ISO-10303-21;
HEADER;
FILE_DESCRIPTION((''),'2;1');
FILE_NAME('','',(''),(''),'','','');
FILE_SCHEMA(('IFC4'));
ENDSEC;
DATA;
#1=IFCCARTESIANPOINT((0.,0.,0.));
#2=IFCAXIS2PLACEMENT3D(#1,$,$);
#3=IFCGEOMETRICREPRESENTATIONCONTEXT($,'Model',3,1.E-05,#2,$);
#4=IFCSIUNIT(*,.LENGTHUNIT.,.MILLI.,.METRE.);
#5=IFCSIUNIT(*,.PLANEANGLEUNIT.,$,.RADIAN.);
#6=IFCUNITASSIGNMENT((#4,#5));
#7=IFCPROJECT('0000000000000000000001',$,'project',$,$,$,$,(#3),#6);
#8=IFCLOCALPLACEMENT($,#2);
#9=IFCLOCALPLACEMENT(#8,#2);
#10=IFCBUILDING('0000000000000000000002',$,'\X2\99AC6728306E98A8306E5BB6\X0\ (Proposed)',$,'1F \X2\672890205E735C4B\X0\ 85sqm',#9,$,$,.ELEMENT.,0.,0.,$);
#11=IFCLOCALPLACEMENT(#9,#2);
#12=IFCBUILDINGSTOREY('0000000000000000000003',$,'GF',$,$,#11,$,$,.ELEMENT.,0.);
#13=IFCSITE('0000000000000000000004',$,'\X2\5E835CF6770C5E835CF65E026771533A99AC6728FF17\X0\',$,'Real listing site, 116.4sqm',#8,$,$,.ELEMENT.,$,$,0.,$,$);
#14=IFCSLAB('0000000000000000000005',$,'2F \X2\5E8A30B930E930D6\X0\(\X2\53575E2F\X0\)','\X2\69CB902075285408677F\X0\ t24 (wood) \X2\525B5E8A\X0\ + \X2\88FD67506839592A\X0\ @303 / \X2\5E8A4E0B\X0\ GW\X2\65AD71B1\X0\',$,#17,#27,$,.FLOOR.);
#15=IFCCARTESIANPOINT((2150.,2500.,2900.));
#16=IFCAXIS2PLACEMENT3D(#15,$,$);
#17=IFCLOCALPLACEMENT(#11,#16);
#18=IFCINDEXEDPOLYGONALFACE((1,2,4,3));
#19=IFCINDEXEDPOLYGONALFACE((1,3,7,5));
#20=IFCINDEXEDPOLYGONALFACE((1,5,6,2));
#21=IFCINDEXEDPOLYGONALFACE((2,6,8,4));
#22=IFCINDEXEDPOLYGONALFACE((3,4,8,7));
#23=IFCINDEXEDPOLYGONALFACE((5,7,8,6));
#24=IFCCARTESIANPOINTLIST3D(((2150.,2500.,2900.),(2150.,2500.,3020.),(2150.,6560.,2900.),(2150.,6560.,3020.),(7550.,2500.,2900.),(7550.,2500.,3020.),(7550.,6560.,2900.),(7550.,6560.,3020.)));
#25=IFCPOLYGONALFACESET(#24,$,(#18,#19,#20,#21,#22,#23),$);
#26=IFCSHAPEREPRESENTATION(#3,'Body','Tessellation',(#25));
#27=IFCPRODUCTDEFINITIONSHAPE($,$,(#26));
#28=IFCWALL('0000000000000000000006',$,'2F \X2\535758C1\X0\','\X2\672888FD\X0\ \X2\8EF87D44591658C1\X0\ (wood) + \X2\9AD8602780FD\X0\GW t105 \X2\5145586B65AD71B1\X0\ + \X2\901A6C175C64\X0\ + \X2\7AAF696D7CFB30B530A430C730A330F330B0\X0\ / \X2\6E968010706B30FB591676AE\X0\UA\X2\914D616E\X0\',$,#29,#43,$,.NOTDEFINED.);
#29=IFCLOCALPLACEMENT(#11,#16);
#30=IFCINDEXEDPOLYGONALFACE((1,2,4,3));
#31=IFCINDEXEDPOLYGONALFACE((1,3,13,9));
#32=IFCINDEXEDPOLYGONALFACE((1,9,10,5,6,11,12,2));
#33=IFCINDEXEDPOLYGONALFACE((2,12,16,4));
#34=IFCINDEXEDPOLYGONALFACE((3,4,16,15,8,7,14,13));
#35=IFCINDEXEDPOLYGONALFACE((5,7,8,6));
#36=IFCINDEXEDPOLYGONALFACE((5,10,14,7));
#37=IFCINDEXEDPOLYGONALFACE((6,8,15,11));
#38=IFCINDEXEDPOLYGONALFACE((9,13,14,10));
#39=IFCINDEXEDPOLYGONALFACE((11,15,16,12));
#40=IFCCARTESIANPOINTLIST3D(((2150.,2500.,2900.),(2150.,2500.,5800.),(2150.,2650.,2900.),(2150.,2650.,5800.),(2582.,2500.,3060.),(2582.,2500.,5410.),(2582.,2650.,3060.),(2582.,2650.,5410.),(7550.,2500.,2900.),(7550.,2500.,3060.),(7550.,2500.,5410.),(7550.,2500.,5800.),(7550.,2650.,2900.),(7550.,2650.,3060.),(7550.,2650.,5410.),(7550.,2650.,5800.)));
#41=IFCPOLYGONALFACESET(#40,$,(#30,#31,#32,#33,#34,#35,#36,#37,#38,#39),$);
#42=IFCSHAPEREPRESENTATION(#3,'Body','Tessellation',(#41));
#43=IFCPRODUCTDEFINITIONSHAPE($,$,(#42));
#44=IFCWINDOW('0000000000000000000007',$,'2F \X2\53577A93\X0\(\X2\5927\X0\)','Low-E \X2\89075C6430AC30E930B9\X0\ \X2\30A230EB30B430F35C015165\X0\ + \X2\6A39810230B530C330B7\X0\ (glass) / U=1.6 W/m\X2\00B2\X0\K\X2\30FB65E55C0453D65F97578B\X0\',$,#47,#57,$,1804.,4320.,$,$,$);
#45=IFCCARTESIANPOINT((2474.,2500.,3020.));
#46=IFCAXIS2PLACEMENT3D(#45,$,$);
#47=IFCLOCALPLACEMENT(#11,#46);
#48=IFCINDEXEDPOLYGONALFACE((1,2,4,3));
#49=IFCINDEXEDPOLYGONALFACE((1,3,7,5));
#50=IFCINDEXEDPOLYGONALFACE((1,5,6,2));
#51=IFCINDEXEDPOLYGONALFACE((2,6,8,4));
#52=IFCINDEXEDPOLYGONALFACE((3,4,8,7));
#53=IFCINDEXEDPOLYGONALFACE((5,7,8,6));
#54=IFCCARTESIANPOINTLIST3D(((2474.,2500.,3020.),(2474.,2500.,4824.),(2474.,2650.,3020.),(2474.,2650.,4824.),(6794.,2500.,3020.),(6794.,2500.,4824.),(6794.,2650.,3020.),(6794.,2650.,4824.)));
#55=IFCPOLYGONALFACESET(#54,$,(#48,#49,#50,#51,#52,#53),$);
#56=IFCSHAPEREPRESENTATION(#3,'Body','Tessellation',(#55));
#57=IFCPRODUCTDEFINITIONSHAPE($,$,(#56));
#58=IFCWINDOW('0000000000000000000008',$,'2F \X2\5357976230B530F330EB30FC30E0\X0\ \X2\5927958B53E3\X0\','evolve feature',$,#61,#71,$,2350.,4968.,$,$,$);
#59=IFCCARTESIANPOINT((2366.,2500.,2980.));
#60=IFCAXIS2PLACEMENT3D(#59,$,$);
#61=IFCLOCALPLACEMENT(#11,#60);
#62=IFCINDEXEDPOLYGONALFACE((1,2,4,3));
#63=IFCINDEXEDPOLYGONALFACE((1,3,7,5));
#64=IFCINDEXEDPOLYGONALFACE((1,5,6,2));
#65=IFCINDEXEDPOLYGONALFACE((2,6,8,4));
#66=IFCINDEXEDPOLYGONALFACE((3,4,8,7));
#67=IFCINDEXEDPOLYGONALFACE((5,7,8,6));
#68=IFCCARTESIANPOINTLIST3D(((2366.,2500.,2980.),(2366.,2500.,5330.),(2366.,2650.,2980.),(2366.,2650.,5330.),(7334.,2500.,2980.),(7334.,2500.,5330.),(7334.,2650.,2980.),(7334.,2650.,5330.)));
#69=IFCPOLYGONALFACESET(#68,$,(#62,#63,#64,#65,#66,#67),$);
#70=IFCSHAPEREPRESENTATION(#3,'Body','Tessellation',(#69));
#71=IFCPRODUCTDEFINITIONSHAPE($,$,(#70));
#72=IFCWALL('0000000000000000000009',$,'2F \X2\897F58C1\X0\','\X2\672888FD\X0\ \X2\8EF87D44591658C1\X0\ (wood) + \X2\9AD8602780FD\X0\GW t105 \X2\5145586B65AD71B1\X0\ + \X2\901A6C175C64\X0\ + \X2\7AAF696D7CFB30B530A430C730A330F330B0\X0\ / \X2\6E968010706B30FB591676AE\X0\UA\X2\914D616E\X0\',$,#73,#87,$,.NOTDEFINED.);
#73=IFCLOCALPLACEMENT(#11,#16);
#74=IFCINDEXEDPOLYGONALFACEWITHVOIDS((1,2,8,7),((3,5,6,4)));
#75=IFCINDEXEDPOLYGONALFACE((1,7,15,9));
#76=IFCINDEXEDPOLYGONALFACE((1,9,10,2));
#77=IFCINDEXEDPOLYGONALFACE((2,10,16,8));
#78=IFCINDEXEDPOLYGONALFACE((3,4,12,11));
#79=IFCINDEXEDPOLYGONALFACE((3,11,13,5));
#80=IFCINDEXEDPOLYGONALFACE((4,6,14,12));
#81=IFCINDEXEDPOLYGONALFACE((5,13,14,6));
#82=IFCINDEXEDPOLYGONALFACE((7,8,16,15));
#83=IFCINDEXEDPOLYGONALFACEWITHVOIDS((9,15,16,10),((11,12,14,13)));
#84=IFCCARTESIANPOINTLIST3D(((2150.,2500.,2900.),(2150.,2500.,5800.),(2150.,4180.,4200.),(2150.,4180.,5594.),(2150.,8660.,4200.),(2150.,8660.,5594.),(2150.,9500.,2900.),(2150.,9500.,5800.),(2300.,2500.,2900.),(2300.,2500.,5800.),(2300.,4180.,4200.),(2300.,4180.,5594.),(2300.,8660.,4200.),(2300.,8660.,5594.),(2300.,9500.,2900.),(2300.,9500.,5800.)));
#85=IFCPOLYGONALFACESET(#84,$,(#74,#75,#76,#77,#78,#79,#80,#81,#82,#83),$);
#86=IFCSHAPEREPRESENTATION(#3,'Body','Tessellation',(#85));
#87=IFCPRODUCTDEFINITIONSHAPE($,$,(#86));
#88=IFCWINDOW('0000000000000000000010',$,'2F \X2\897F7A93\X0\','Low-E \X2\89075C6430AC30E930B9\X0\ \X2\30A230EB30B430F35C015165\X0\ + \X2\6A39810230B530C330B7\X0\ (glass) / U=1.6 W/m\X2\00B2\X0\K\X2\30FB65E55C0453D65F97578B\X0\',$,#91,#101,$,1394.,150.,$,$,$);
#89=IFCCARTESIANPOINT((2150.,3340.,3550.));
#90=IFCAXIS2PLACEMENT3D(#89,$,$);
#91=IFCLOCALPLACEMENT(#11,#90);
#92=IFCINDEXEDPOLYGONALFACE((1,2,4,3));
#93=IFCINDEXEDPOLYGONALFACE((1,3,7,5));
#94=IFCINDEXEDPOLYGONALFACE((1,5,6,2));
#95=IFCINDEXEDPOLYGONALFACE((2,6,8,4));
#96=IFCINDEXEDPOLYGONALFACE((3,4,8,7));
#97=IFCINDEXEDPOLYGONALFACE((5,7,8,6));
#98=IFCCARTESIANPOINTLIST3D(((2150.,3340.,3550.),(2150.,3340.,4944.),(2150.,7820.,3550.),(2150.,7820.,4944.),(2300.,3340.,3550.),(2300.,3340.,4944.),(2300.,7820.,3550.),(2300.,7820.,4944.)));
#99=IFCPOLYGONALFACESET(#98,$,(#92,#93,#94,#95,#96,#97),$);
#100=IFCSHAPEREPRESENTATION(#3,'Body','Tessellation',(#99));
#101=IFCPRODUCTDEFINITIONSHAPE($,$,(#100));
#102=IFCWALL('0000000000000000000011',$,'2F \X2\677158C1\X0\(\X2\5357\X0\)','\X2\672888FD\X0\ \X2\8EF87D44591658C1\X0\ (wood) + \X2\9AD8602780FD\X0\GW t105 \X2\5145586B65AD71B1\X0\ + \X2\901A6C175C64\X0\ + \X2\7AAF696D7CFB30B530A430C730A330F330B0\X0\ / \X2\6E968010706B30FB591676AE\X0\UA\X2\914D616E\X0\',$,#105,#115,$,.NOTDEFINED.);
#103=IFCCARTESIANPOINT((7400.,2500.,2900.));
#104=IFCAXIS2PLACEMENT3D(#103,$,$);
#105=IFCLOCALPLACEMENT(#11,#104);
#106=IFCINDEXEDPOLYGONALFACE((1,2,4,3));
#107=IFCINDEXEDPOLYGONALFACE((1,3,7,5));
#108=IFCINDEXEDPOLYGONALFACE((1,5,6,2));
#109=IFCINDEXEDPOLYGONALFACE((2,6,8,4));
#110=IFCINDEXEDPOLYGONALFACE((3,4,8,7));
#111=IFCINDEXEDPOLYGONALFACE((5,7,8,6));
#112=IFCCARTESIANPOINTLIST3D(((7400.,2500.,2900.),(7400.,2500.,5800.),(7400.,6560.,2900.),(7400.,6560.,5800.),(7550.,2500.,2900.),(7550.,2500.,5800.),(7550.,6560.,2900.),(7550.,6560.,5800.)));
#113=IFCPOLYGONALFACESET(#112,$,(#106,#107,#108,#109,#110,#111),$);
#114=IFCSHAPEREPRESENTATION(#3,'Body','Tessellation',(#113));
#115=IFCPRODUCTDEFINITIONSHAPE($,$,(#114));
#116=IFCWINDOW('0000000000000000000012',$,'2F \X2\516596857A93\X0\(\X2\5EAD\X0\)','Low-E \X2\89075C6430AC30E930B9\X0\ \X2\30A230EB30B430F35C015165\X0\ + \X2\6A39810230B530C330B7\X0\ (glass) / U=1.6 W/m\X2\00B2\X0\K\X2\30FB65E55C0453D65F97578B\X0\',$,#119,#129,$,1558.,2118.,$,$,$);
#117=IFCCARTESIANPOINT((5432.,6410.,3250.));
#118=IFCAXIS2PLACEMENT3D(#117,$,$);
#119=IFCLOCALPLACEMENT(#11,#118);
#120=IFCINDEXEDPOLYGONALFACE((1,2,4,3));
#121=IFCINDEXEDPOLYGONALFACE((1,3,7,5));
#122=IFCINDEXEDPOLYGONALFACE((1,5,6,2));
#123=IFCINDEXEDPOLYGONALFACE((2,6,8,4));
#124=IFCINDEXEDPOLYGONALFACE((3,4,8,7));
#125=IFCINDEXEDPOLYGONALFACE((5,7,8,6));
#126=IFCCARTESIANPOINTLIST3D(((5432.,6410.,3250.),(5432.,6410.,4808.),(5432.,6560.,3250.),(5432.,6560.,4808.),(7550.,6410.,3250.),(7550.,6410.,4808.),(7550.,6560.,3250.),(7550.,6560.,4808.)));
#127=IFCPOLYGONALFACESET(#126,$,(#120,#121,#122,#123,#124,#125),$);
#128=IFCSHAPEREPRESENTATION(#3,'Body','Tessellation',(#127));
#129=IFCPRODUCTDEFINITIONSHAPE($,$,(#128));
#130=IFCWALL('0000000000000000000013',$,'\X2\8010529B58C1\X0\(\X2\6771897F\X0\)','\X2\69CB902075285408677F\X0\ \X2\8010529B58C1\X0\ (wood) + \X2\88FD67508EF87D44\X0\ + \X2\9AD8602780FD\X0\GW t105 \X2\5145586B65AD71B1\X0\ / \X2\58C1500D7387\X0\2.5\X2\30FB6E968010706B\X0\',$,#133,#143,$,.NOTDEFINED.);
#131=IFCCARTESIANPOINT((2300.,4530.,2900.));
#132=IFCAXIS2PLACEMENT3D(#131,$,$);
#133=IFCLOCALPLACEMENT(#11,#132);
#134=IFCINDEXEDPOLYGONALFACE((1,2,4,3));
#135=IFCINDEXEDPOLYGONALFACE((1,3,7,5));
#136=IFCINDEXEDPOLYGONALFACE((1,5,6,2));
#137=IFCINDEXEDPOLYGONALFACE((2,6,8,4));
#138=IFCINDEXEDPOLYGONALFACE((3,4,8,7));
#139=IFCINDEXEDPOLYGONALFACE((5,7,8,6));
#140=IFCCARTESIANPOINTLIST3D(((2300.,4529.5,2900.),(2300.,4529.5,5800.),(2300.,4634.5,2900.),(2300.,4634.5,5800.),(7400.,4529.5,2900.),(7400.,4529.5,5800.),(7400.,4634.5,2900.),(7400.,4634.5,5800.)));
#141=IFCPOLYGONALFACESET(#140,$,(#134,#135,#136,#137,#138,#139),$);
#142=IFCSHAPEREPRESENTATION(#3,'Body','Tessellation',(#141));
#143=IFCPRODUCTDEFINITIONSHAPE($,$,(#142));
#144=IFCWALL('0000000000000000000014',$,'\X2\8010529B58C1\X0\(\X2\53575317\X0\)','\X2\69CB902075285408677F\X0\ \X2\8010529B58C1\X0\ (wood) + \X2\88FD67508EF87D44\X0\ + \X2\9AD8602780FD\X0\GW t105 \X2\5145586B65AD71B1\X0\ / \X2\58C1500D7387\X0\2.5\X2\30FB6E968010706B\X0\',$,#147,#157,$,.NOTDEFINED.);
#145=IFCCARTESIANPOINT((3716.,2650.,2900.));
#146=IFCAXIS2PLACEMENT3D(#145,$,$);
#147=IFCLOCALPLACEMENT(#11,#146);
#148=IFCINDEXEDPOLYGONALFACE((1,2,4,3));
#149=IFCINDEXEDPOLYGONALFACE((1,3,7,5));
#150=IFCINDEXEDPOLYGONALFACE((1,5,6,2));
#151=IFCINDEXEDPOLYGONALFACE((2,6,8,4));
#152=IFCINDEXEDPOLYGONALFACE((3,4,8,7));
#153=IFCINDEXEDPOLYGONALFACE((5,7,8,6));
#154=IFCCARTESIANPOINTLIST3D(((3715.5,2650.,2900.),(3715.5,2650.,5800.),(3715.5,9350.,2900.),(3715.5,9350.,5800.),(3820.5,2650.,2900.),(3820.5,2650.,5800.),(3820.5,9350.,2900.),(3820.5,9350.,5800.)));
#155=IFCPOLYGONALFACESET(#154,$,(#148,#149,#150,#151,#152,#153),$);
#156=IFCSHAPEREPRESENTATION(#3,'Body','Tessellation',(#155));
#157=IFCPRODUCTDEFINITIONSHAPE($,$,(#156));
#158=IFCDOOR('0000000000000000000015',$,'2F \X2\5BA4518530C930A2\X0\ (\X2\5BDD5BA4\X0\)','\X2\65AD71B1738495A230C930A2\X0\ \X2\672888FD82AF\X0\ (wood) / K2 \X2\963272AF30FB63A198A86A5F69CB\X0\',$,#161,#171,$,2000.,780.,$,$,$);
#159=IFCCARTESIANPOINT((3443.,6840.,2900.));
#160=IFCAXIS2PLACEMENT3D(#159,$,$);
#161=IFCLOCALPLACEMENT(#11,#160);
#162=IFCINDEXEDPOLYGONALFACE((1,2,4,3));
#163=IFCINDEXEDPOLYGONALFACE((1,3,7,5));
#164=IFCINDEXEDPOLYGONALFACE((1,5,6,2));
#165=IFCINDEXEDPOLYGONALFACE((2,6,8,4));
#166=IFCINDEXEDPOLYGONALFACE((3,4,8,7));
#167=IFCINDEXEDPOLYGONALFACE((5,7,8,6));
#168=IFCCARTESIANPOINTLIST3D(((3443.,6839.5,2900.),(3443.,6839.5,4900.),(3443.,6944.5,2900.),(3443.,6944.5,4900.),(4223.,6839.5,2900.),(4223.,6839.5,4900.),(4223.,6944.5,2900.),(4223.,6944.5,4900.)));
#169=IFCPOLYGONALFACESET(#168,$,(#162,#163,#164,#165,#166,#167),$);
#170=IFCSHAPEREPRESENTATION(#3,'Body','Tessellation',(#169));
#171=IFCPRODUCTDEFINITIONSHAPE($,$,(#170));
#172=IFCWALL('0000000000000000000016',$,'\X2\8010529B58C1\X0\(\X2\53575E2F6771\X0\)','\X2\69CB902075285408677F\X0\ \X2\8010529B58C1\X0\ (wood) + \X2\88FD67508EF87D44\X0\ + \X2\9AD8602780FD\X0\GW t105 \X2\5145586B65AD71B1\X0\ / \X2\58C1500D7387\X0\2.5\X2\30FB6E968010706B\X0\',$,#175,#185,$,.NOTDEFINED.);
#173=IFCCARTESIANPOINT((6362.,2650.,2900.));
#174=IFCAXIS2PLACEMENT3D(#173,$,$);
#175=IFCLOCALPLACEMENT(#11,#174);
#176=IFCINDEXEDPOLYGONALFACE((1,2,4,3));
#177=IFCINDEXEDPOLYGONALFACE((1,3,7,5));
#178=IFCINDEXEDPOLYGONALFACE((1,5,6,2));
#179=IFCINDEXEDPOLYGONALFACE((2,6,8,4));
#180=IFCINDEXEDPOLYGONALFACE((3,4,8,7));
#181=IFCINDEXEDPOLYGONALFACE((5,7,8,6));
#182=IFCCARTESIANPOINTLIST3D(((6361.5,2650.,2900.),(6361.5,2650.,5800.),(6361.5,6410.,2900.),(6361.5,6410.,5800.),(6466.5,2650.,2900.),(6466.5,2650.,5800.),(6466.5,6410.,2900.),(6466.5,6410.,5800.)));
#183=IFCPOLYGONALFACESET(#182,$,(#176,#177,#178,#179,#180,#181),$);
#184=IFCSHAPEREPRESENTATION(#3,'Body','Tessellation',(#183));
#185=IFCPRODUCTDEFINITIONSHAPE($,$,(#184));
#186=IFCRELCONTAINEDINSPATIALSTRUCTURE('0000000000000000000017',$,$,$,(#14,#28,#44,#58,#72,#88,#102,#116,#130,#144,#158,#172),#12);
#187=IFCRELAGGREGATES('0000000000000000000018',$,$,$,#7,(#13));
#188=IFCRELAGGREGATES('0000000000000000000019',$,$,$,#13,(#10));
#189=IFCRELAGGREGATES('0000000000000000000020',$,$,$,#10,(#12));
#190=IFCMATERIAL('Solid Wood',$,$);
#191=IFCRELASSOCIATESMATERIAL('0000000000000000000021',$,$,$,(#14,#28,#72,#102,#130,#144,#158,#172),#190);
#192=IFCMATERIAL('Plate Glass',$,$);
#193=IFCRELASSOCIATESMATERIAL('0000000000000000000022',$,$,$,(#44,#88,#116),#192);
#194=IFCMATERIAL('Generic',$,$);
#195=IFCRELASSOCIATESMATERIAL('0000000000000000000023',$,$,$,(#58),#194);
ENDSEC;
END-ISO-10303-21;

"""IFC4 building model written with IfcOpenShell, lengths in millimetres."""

from ifc_helpers import new_model, si_unit, frame, frame_2d, origin, place, context, project, spatial, rectangle, extrude, material, element, fill, save


model = new_model("IFC4")

# Units and contexts
model_context = context("Model", 3, precision=1e-05, world=origin())
ifc_project = project(units=[si_unit("LENGTHUNIT", "METRE", prefix="MILLI"), si_unit("PLANEANGLEUNIT", "RADIAN")], contexts=[model_context])

# Site, building, storey
site_placement = place(None, origin())
site = spatial("IfcSite", under=ifc_project, at=site_placement, Name="広島県広島市東区馬木７", ObjectType="Real listing site, 116.4sqm", CompositionType="ELEMENT", RefElevation=0.0)
building_placement = place(site_placement, origin())
building = spatial("IfcBuilding", under=site, at=building_placement, Name="馬木の風の家 (Proposed)", ObjectType="1F 木造平屋 85sqm", CompositionType="ELEMENT", ElevationOfRefHeight=0.0, ElevationOfTerrain=0.0)
storey_placement = place(building_placement, origin())
storey = spatial("IfcBuildingStorey", under=building, at=storey_placement, Name="GF", CompositionType="ELEMENT", Elevation=0.0)

# Slab
ifc_material_1 = material(Name="Solid Wood")
slab_placement = place(storey_placement, frame((2150.0, 2500.0, 2900.0)))
element("IfcSlab", 1, at=slab_placement, inside=storey, material=ifc_material_1, Name="2F 床スラブ(南帯)", Description="構造用合板 t24 (wood) 剛床 + 製材根太 @303 / 床下 GW断熱", PredefinedType="FLOOR", context=model_context, shape_type="SweptSolid", body=[
    extrude(rectangle(XDim=5400.0, YDim=4060.0, at=frame_2d((2700.0, 2030.0))), frame((2150.0, 2500.0, 2900.0)), (0.0, 0.0, 1.0), 120.0),
])

# Wall, openings, windows
wall_1_placement = place(storey_placement, frame((2150.0, 2500.0, 2900.0)))
wall_1 = element("IfcWall", 2, at=wall_1_placement, inside=storey, material=ifc_material_1, Name="2F 南壁", Description="木製 軸組外壁 (wood) + 高性能GW t105 充填断熱 + 通気層 + 窯業系サイディング / 準耐火・外皮UA配慮", PredefinedType="NOTDEFINED", context=model_context, shape_type="SweptSolid", body=[
    extrude(rectangle(XDim=5400.0, YDim=150.0, at=frame_2d((2700.0, 75.0))), frame((2150.0, 2500.0, 2900.0)), (0.0, 0.0, 1.0), 2900.0),
])
opening_1_placement = place(storey_placement, frame((2474.0, 2500.0, 3020.0)))
opening_1 = element("IfcOpeningElement", 3, at=opening_1_placement, cuts=wall_1, PredefinedType="NOTDEFINED", context=model_context, shape_type="SweptSolid", body=[
    extrude(rectangle(XDim=4320.0, YDim=150.0, at=frame_2d((2160.0, 75.0))), frame((2474.0, 2500.0, 3020.0)), (0.0, 0.0, 1.0), 1804.0),
])
opening_2_placement = place(storey_placement, frame((2366.0, 2500.0, 2980.0)))
opening_2 = element("IfcOpeningElement", 4, at=opening_2_placement, cuts=wall_1, PredefinedType="NOTDEFINED", context=model_context, shape_type="SweptSolid", body=[
    extrude(rectangle(XDim=4968.0, YDim=150.0, at=frame_2d((2484.0, 75.0))), frame((2366.0, 2500.0, 2980.0)), (0.0, 0.0, 1.0), 2350.0),
])
ifc_material_2 = material(Name="Plate Glass")
window_1_placement = place(storey_placement, frame((2474.0, 2500.0, 3020.0)))
window_1 = element("IfcWindow", 5, at=window_1_placement, inside=storey, material=ifc_material_2, Name="2F 南窓(大)", Description="Low-E 複層ガラス アルゴン封入 + 樹脂サッシ (glass) / U=1.6 W/m²K・日射取得型", OverallHeight=1804.0, OverallWidth=4320.0, context=model_context, shape_type="SweptSolid", body=[
    extrude(rectangle(XDim=4320.0, YDim=150.0, at=frame_2d((2160.0, 75.0))), frame((2474.0, 2500.0, 3020.0)), (0.0, 0.0, 1.0), 1804.0),
])
fill(opening_1, window_1)
ifc_material_3 = material(Name="Generic")
window_2_placement = place(storey_placement, frame((2366.0, 2500.0, 2980.0)))
window_2 = element("IfcWindow", 6, at=window_2_placement, inside=storey, material=ifc_material_3, Name="2F 南面サンルーム 大開口", Description="evolve feature", OverallHeight=2350.0, OverallWidth=4968.0, context=model_context, shape_type="SweptSolid", body=[
    extrude(rectangle(XDim=4968.0, YDim=150.0, at=frame_2d((2484.0, 75.0))), frame((2366.0, 2500.0, 2980.0)), (0.0, 0.0, 1.0), 2350.0),
])
fill(opening_2, window_2)

# Walls, openings, windows
wall_2_placement = place(storey_placement, frame((2150.0, 2500.0, 2900.0)))
wall_2 = element("IfcWall", 7, at=wall_2_placement, inside=storey, material=ifc_material_1, Name="2F 西壁", Description="木製 軸組外壁 (wood) + 高性能GW t105 充填断熱 + 通気層 + 窯業系サイディング / 準耐火・外皮UA配慮", PredefinedType="NOTDEFINED", context=model_context, shape_type="SweptSolid", body=[
    extrude(rectangle(XDim=150.0, YDim=7000.0, at=frame_2d((75.0, 3500.0))), frame((2150.0, 2500.0, 2900.0)), (0.0, 0.0, 1.0), 2900.0),
])
opening_3_placement = place(storey_placement, frame((2150.0, 3340.0, 3550.0)))
opening_3 = element("IfcOpeningElement", 8, at=opening_3_placement, cuts=wall_2, PredefinedType="NOTDEFINED", context=model_context, shape_type="SweptSolid", body=[
    extrude(rectangle(XDim=150.0, YDim=4480.0, at=frame_2d((75.0, 2240.0))), frame((2150.0, 3340.0, 3550.0)), (0.0, 0.0, 1.0), 1394.0),
])
window_3_placement = place(storey_placement, frame((2150.0, 3340.0, 3550.0)))
window_3 = element("IfcWindow", 9, at=window_3_placement, inside=storey, material=ifc_material_2, Name="2F 西窓", Description="Low-E 複層ガラス アルゴン封入 + 樹脂サッシ (glass) / U=1.6 W/m²K・日射取得型", OverallHeight=1394.0, OverallWidth=150.0, context=model_context, shape_type="SweptSolid", body=[
    extrude(rectangle(XDim=150.0, YDim=4480.0, at=frame_2d((75.0, 2240.0))), frame((2150.0, 3340.0, 3550.0)), (0.0, 0.0, 1.0), 1394.0),
])
fill(opening_3, window_3)
wall_3_placement = place(storey_placement, frame((7400.0, 2500.0, 2900.0)))
wall_3 = element("IfcWall", 10, at=wall_3_placement, inside=storey, material=ifc_material_1, Name="2F 東壁(南)", Description="木製 軸組外壁 (wood) + 高性能GW t105 充填断熱 + 通気層 + 窯業系サイディング / 準耐火・外皮UA配慮", PredefinedType="NOTDEFINED", context=model_context, shape_type="SweptSolid", body=[
    extrude(rectangle(XDim=150.0, YDim=4060.0, at=frame_2d((75.0, 2030.0))), frame((7400.0, 2500.0, 2900.0)), (0.0, 0.0, 1.0), 2900.0),
])
opening_4_placement = place(storey_placement, frame((5432.0, 6410.0, 3250.0)))
opening_4 = element("IfcOpeningElement", 11, at=opening_4_placement, cuts=wall_3, PredefinedType="NOTDEFINED", context=model_context, shape_type="SweptSolid", body=[
    extrude(rectangle(XDim=2118.0, YDim=150.0, at=frame_2d((1059.0, 75.0))), frame((5432.0, 6410.0, 3250.0)), (0.0, 0.0, 1.0), 1558.0),
])
window_4_placement = place(storey_placement, frame((5432.0, 6410.0, 3250.0)))
window_4 = element("IfcWindow", 12, at=window_4_placement, inside=storey, material=ifc_material_2, Name="2F 入隅窓(庭)", Description="Low-E 複層ガラス アルゴン封入 + 樹脂サッシ (glass) / U=1.6 W/m²K・日射取得型", OverallHeight=1558.0, OverallWidth=2118.0, context=model_context, shape_type="SweptSolid", body=[
    extrude(rectangle(XDim=2118.0, YDim=150.0, at=frame_2d((1059.0, 75.0))), frame((5432.0, 6410.0, 3250.0)), (0.0, 0.0, 1.0), 1558.0),
])
fill(opening_4, window_4)

# Wall
wall_4_placement = place(storey_placement, frame((2300.0, 4530.0, 2900.0)))
element("IfcWall", 13, at=wall_4_placement, inside=storey, material=ifc_material_1, Name="耐力壁(東西)", Description="構造用合板 耐力壁 (wood) + 製材軸組 + 高性能GW t105 充填断熱 / 壁倍率2.5・準耐火", PredefinedType="NOTDEFINED", context=model_context, shape_type="SweptSolid", body=[
    extrude(rectangle(XDim=5100.0, YDim=105.0, at=frame_2d((2550.0, 52.0))), frame((2300.0, 4530.0, 2900.0)), (0.0, 0.0, 1.0), 2900.0),
])

# Wall, opening, door
wall_5_placement = place(storey_placement, frame((3716.0, 2650.0, 2900.0)))
wall_5 = element("IfcWall", 14, at=wall_5_placement, inside=storey, material=ifc_material_1, Name="耐力壁(南北)", Description="構造用合板 耐力壁 (wood) + 製材軸組 + 高性能GW t105 充填断熱 / 壁倍率2.5・準耐火", PredefinedType="NOTDEFINED", context=model_context, shape_type="SweptSolid", body=[
    extrude(rectangle(XDim=105.0, YDim=6700.0, at=frame_2d((52.0, 3350.0))), frame((3716.0, 2650.0, 2900.0)), (0.0, 0.0, 1.0), 2900.0),
])
opening_5_placement = place(storey_placement, frame((3443.0, 6840.0, 2900.0)))
opening_5 = element("IfcOpeningElement", 15, at=opening_5_placement, cuts=wall_5, PredefinedType="NOTDEFINED", context=model_context, shape_type="SweptSolid", body=[
    extrude(rectangle(XDim=780.0, YDim=105.0, at=frame_2d((390.0, 52.0))), frame((3443.0, 6840.0, 2900.0)), (0.0, 0.0, 1.0), 2000.0),
])
door_placement = place(storey_placement, frame((3443.0, 6840.0, 2900.0)))
door = element("IfcDoor", 16, at=door_placement, inside=storey, material=ifc_material_1, Name="2F 室内ドア (寝室)", Description="断熱玄関ドア 木製芯 (wood) / K2 防犯・採風機構", OverallHeight=2000.0, OverallWidth=780.0, context=model_context, shape_type="SweptSolid", body=[
    extrude(rectangle(XDim=780.0, YDim=105.0, at=frame_2d((390.0, 52.0))), frame((3443.0, 6840.0, 2900.0)), (0.0, 0.0, 1.0), 2000.0),
])
fill(opening_5, door)

# Wall
wall_6_placement = place(storey_placement, frame((6362.0, 2650.0, 2900.0)))
element("IfcWall", 17, at=wall_6_placement, inside=storey, material=ifc_material_1, Name="耐力壁(南帯東)", Description="構造用合板 耐力壁 (wood) + 製材軸組 + 高性能GW t105 充填断熱 / 壁倍率2.5・準耐火", PredefinedType="NOTDEFINED", context=model_context, shape_type="SweptSolid", body=[
    extrude(rectangle(XDim=105.0, YDim=3760.0, at=frame_2d((52.0, 1880.0))), frame((6362.0, 2650.0, 2900.0)), (0.0, 0.0, 1.0), 2900.0),
])

save(model, "model.ifc")
